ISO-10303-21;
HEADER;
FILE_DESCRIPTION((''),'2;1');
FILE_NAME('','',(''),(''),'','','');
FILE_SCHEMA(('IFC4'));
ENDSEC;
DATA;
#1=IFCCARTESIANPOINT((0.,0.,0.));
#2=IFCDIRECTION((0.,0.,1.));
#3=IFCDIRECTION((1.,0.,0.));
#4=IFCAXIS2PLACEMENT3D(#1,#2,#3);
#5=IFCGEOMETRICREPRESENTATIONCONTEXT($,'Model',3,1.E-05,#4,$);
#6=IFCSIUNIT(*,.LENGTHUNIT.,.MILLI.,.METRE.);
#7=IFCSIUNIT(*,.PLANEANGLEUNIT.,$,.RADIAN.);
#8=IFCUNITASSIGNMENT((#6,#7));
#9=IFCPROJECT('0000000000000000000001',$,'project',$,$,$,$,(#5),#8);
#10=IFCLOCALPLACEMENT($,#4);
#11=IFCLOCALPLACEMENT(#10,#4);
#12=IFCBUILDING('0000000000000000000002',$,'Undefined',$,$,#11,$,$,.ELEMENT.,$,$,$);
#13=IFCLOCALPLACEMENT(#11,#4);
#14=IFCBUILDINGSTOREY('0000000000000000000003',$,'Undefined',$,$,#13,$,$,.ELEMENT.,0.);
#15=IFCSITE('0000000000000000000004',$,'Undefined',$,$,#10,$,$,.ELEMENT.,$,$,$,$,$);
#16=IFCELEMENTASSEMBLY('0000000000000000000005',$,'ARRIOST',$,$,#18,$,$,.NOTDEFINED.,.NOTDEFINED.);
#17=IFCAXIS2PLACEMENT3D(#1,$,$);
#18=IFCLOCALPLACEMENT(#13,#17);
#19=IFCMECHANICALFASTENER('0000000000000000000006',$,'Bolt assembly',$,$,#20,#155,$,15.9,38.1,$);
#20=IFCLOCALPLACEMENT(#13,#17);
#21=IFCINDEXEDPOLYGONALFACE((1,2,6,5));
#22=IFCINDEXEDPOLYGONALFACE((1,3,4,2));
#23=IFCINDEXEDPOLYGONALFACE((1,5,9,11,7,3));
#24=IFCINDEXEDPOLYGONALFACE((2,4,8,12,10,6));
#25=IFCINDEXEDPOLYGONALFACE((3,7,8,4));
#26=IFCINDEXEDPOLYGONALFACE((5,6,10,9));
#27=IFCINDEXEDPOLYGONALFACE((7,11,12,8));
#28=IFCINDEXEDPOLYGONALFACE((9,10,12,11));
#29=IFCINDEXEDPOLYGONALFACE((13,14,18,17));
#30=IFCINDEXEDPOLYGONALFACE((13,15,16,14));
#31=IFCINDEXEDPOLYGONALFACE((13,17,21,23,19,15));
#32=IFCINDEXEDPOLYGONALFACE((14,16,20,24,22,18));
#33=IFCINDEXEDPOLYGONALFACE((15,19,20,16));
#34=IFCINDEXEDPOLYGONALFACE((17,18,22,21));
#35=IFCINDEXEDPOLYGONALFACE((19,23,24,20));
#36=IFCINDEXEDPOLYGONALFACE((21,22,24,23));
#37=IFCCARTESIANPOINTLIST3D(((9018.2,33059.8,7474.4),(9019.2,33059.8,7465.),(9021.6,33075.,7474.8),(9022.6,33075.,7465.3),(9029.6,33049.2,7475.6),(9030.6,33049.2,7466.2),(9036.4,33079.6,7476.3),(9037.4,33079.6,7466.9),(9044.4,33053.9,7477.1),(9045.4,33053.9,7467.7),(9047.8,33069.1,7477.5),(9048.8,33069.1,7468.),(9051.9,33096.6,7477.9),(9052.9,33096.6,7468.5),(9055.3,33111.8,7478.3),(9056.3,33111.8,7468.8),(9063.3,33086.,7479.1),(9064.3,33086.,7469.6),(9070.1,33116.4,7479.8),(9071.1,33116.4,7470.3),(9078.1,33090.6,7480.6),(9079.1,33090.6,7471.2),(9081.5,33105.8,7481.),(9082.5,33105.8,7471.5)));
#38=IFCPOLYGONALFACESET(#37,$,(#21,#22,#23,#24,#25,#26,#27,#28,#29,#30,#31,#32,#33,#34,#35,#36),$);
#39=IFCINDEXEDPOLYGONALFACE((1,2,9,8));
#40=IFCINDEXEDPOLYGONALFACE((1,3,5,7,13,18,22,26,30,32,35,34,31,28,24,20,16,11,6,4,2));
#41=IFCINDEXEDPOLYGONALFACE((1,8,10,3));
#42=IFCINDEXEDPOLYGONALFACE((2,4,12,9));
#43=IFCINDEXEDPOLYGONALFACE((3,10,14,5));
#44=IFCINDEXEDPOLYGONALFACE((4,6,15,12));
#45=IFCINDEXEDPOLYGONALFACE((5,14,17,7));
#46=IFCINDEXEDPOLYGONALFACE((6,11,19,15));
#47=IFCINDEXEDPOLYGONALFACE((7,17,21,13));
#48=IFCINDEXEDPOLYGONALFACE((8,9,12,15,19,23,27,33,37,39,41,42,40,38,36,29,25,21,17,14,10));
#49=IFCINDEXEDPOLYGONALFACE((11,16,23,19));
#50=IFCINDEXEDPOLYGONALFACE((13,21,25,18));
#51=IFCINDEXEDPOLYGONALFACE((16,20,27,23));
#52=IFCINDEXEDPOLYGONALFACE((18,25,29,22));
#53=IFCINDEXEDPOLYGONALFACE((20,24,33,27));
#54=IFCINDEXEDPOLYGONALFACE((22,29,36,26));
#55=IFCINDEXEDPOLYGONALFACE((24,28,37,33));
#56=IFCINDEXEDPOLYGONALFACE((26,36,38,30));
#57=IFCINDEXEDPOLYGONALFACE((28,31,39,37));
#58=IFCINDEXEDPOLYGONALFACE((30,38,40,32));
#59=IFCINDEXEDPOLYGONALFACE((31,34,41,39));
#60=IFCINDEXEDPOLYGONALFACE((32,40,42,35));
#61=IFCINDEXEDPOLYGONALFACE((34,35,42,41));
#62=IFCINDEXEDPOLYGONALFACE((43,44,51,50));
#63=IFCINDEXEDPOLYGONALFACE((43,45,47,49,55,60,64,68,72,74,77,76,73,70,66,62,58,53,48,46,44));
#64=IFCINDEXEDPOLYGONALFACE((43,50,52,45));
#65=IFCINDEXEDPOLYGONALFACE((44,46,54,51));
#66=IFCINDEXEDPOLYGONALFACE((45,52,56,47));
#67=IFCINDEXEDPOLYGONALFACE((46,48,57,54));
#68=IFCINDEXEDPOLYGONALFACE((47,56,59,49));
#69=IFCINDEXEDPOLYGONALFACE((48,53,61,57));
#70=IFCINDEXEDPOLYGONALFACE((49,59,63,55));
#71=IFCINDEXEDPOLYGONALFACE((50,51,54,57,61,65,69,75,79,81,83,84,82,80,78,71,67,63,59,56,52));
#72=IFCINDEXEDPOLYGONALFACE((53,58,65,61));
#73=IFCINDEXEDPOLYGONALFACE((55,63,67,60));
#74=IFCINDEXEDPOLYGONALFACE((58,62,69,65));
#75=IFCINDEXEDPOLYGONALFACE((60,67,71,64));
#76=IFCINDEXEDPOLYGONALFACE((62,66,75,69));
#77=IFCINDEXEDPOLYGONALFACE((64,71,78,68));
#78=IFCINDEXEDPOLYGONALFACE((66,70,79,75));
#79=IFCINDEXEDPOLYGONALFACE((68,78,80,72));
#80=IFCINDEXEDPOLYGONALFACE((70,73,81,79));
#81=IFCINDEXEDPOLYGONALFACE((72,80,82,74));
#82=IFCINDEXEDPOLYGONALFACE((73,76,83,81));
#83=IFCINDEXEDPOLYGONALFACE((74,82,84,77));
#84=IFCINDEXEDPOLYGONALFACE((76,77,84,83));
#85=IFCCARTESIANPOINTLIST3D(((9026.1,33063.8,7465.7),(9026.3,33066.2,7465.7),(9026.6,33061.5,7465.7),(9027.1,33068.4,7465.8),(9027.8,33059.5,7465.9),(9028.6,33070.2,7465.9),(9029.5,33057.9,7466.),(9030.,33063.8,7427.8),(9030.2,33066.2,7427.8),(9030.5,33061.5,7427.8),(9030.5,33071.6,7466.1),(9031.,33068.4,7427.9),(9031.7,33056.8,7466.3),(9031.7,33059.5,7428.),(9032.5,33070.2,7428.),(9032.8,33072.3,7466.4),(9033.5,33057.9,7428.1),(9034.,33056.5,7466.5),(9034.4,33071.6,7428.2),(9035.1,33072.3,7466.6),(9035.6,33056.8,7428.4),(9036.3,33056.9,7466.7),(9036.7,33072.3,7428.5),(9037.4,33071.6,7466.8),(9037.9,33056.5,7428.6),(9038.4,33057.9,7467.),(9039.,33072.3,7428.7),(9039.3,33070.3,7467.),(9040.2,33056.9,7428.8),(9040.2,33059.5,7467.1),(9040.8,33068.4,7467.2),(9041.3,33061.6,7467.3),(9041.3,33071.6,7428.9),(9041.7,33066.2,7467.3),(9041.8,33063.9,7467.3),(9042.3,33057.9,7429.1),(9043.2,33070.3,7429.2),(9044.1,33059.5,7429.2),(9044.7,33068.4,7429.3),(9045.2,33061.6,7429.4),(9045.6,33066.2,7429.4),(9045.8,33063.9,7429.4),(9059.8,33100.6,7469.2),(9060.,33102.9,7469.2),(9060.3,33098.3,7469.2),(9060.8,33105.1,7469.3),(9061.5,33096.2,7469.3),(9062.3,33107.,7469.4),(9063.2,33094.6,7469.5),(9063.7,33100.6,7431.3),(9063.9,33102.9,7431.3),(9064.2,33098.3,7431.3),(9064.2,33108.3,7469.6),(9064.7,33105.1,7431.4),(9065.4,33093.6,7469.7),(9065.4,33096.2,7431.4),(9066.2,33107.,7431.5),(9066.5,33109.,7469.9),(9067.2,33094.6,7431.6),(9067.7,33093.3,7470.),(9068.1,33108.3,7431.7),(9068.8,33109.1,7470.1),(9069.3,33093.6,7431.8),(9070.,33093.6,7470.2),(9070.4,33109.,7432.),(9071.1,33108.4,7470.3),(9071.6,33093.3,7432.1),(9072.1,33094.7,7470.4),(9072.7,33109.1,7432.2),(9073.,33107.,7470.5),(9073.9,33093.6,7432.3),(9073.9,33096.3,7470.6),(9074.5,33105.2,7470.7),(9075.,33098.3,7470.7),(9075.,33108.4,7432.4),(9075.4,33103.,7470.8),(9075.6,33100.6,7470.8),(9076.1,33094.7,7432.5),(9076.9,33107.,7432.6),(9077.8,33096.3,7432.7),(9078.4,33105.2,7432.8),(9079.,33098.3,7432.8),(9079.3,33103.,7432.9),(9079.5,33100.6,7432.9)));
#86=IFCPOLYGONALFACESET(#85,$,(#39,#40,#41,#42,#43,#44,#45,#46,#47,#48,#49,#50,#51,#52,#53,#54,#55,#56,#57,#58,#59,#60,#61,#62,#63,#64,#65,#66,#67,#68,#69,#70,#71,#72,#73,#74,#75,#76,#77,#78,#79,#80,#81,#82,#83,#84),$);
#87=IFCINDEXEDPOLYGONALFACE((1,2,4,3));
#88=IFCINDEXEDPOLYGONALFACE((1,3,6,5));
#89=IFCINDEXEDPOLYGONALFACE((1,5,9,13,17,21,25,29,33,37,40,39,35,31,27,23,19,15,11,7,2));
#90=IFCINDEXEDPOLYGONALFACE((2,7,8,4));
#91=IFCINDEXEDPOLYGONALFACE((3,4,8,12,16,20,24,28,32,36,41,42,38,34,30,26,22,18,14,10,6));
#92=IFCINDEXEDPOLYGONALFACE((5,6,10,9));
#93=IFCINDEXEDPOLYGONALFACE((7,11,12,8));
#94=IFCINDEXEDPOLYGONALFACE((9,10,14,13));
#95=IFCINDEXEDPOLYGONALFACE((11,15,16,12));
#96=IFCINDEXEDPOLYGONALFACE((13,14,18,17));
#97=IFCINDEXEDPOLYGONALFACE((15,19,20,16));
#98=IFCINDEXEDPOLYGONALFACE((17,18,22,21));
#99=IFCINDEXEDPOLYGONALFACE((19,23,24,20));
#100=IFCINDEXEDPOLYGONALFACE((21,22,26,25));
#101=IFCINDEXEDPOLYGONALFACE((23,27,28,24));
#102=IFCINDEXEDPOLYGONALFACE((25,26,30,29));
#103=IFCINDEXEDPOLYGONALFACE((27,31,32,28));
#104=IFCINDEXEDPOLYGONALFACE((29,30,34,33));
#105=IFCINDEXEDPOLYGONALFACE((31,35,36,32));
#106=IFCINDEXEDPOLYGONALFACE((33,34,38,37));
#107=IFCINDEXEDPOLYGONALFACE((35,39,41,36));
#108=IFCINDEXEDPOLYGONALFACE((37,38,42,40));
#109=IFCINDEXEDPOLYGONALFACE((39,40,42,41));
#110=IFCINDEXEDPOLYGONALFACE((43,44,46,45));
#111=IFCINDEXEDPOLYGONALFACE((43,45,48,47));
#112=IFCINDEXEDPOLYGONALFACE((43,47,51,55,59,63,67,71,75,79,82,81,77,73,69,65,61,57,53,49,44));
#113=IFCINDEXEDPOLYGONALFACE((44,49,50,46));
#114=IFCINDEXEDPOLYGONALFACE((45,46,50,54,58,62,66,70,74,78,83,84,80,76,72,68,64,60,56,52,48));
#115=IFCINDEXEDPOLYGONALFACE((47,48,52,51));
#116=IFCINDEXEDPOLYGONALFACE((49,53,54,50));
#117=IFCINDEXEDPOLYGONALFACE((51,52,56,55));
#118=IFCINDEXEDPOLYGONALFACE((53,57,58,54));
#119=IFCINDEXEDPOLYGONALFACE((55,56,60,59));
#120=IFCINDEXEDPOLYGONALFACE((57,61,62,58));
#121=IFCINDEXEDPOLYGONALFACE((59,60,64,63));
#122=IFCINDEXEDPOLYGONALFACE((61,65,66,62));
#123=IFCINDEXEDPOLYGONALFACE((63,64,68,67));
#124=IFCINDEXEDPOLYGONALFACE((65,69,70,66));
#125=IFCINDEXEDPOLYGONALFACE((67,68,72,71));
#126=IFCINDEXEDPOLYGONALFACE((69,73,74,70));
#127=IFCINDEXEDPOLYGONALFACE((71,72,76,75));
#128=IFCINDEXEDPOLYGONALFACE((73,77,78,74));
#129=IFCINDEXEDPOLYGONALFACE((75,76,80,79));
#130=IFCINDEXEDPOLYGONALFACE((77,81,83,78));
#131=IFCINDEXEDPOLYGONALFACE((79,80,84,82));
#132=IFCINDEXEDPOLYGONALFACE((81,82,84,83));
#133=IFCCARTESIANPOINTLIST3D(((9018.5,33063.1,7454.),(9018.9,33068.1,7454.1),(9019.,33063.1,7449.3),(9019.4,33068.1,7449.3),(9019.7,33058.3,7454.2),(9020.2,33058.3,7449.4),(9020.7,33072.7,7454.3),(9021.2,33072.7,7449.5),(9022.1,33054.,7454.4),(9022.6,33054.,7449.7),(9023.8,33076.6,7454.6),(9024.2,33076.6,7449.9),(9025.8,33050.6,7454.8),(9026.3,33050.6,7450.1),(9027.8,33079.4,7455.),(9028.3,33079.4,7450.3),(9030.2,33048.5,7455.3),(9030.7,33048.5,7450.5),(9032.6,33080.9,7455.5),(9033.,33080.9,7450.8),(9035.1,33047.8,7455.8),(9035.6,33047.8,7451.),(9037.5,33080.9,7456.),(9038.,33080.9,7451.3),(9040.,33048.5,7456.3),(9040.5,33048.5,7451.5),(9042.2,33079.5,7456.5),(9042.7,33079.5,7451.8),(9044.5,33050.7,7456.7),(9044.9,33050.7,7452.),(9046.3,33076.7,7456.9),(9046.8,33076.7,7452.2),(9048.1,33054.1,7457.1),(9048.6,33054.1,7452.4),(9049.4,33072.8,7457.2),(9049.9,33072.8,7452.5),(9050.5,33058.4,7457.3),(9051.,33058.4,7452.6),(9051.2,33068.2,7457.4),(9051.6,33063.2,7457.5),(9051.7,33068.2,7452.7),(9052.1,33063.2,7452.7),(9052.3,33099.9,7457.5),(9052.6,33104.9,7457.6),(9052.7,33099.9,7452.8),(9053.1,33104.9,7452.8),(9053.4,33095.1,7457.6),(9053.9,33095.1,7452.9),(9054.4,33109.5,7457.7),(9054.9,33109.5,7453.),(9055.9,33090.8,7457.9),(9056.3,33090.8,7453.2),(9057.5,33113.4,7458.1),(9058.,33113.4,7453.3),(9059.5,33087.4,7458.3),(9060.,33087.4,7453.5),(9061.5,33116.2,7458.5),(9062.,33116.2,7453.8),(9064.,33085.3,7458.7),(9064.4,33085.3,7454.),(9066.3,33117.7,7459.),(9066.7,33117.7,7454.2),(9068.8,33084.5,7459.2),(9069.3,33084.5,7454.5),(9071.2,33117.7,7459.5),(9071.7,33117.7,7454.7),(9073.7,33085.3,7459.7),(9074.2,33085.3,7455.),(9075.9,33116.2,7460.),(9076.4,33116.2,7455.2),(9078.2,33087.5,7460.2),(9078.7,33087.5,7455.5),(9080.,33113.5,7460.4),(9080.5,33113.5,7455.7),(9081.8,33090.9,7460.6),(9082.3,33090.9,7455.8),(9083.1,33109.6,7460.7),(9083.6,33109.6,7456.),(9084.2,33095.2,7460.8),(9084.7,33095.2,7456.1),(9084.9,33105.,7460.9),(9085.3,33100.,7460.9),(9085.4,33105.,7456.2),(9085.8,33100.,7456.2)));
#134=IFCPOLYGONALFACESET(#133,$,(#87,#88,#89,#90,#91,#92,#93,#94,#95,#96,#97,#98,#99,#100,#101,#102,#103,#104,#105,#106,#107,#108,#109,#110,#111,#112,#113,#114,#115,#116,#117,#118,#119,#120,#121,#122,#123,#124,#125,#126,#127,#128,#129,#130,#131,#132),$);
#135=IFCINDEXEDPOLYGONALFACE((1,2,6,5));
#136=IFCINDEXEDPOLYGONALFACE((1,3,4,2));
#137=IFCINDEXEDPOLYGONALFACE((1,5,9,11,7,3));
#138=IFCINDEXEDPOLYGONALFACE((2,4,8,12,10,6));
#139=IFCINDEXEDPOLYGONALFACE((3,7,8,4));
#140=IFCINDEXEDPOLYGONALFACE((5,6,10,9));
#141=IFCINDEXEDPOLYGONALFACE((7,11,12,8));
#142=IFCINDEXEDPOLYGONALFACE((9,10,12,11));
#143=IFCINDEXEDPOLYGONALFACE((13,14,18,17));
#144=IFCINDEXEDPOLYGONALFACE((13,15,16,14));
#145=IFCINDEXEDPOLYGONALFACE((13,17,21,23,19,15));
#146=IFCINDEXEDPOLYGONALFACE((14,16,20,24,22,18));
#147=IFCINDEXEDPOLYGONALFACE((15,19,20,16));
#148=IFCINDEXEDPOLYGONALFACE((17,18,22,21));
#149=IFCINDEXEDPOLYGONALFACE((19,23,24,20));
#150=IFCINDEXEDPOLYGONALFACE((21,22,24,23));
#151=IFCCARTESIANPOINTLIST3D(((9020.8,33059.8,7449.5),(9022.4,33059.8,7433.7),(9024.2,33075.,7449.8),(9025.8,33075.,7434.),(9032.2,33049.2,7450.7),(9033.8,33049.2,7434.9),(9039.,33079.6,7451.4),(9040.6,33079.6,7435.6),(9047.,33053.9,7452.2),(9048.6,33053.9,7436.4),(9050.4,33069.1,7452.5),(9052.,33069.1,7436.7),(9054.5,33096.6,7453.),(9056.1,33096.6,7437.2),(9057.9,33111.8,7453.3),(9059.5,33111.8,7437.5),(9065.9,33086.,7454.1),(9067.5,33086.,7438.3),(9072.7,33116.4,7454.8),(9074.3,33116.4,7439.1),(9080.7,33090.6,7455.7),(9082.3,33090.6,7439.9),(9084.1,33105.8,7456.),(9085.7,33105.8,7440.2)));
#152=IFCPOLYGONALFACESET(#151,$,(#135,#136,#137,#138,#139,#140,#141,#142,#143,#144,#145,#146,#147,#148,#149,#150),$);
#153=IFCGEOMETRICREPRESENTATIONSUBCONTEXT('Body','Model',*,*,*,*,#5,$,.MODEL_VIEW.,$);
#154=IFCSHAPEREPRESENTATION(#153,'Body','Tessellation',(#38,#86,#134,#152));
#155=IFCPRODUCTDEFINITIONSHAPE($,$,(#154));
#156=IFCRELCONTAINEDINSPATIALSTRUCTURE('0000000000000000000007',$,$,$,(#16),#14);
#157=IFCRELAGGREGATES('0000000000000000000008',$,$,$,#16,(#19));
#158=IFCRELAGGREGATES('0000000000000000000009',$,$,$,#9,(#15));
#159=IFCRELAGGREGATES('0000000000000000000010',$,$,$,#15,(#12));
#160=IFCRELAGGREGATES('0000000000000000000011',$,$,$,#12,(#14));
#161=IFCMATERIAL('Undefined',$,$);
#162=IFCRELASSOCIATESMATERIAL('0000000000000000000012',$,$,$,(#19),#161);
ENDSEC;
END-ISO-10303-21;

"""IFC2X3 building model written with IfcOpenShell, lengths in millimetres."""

from ifc_helpers import new_model, si_unit, frame, origin_with_axes, origin_2d_with_axis, place, context, subcontext, project, spatial, polyline, circle, outline, extrude, source, transform, mapped, material, element, aggregate, save


model = new_model("IFC2X3")

# Units and contexts
model_context = context("Model", 3, precision=1e-05, world=origin_with_axes())
body_context = subcontext(model_context, "Body", "Model", "MODEL_VIEW")
ifc_project = project(units=[si_unit("LENGTHUNIT", "METRE", prefix="MILLI"), si_unit("PLANEANGLEUNIT", "RADIAN")], contexts=[model_context])

# Site, building, storey
site_placement = place(None, origin_with_axes())
site = spatial("IfcSite", under=ifc_project, at=site_placement, Name="Undefined", CompositionType="ELEMENT")
building_placement = place(site_placement, origin_with_axes())
building = spatial("IfcBuilding", under=site, at=building_placement, Name="Undefined", CompositionType="ELEMENT")
storey_placement = place(building_placement, origin_with_axes())
storey = spatial("IfcBuildingStorey", under=building, at=storey_placement, Name="Undefined", CompositionType="ELEMENT", Elevation=0.0)

# Shared definitions
ifc_material_1 = material(Name="Undefined")

# Element assembly, mechanical fastener
assembly_1_placement = place(storey_placement, origin_with_axes())
assembly_1 = element("IfcElementAssembly", 1, at=assembly_1_placement, inside=storey, Name="ARRIOST", AssemblyPlace="NOTDEFINED", PredefinedType="NOTDEFINED")
shared_shape_1 = source(origin_with_axes(), body_context, "Body", "SweptSolid", [
    extrude(outline(polyline([(13.5, -7.8), (13.5, 7.8), (0.0, 15.6), (-13.5, 7.8), (-13.5, -7.8), (0.0, -15.6), (13.5, -7.8)])), frame((0.0, -15.5, 0.0), z_axis=(0.0, 1.0, 0.0), x_axis=(1.0, 0.0, 0.0)), (0.0, 0.0, 1.0), 9.5),
    extrude(circle(Radius=7.9, at=origin_2d_with_axis()), frame((0.0, -6.0, 0.0), z_axis=(0.0, 1.0, 0.0), x_axis=(1.0, 0.0, 0.0)), (0.0, 0.0, 1.0), 38.1),
    extrude(circle(Radius=16.7, at=origin_2d_with_axis()), frame((0.0, 4.8, 0.0), z_axis=(0.0, 1.0, 0.0), x_axis=(1.0, 0.0, 0.0)), (0.0, 0.0, 1.0), 4.8),
    extrude(outline(polyline([(13.5, -7.8), (13.5, 7.8), (0.0, 15.6), (-13.5, 7.8), (-13.5, -7.8), (0.0, -15.6), (13.5, -7.8)])), frame((0.0, 9.6, 0.0), z_axis=(0.0, 1.0, 0.0), x_axis=(1.0, 0.0, 0.0)), (0.0, 0.0, 1.0), 15.9),
])
mechanical_fastener_1_placement = place(assembly_1_placement, frame((9034.6, 33064.4, 7460.5), z_axis=(-0.731384, 0.677774, -0.075494), x_axis=(0.674192, 0.73527, 0.069591)))
mechanical_fastener_1 = element("IfcMechanicalFastener", 2, at=mechanical_fastener_1_placement, material=ifc_material_1, Name="Bolt assembly", NominalDiameter=15.9, NominalLength=38.1, context=body_context, shape_type="MappedRepresentation", body=[
    mapped(shared_shape_1, transform((0.0, 0.0, 0.0))),
    mapped(shared_shape_1, transform((50.0, 0.0, 0.0))),
])
aggregate(assembly_1, [mechanical_fastener_1])

save(model, "model.ifc")
